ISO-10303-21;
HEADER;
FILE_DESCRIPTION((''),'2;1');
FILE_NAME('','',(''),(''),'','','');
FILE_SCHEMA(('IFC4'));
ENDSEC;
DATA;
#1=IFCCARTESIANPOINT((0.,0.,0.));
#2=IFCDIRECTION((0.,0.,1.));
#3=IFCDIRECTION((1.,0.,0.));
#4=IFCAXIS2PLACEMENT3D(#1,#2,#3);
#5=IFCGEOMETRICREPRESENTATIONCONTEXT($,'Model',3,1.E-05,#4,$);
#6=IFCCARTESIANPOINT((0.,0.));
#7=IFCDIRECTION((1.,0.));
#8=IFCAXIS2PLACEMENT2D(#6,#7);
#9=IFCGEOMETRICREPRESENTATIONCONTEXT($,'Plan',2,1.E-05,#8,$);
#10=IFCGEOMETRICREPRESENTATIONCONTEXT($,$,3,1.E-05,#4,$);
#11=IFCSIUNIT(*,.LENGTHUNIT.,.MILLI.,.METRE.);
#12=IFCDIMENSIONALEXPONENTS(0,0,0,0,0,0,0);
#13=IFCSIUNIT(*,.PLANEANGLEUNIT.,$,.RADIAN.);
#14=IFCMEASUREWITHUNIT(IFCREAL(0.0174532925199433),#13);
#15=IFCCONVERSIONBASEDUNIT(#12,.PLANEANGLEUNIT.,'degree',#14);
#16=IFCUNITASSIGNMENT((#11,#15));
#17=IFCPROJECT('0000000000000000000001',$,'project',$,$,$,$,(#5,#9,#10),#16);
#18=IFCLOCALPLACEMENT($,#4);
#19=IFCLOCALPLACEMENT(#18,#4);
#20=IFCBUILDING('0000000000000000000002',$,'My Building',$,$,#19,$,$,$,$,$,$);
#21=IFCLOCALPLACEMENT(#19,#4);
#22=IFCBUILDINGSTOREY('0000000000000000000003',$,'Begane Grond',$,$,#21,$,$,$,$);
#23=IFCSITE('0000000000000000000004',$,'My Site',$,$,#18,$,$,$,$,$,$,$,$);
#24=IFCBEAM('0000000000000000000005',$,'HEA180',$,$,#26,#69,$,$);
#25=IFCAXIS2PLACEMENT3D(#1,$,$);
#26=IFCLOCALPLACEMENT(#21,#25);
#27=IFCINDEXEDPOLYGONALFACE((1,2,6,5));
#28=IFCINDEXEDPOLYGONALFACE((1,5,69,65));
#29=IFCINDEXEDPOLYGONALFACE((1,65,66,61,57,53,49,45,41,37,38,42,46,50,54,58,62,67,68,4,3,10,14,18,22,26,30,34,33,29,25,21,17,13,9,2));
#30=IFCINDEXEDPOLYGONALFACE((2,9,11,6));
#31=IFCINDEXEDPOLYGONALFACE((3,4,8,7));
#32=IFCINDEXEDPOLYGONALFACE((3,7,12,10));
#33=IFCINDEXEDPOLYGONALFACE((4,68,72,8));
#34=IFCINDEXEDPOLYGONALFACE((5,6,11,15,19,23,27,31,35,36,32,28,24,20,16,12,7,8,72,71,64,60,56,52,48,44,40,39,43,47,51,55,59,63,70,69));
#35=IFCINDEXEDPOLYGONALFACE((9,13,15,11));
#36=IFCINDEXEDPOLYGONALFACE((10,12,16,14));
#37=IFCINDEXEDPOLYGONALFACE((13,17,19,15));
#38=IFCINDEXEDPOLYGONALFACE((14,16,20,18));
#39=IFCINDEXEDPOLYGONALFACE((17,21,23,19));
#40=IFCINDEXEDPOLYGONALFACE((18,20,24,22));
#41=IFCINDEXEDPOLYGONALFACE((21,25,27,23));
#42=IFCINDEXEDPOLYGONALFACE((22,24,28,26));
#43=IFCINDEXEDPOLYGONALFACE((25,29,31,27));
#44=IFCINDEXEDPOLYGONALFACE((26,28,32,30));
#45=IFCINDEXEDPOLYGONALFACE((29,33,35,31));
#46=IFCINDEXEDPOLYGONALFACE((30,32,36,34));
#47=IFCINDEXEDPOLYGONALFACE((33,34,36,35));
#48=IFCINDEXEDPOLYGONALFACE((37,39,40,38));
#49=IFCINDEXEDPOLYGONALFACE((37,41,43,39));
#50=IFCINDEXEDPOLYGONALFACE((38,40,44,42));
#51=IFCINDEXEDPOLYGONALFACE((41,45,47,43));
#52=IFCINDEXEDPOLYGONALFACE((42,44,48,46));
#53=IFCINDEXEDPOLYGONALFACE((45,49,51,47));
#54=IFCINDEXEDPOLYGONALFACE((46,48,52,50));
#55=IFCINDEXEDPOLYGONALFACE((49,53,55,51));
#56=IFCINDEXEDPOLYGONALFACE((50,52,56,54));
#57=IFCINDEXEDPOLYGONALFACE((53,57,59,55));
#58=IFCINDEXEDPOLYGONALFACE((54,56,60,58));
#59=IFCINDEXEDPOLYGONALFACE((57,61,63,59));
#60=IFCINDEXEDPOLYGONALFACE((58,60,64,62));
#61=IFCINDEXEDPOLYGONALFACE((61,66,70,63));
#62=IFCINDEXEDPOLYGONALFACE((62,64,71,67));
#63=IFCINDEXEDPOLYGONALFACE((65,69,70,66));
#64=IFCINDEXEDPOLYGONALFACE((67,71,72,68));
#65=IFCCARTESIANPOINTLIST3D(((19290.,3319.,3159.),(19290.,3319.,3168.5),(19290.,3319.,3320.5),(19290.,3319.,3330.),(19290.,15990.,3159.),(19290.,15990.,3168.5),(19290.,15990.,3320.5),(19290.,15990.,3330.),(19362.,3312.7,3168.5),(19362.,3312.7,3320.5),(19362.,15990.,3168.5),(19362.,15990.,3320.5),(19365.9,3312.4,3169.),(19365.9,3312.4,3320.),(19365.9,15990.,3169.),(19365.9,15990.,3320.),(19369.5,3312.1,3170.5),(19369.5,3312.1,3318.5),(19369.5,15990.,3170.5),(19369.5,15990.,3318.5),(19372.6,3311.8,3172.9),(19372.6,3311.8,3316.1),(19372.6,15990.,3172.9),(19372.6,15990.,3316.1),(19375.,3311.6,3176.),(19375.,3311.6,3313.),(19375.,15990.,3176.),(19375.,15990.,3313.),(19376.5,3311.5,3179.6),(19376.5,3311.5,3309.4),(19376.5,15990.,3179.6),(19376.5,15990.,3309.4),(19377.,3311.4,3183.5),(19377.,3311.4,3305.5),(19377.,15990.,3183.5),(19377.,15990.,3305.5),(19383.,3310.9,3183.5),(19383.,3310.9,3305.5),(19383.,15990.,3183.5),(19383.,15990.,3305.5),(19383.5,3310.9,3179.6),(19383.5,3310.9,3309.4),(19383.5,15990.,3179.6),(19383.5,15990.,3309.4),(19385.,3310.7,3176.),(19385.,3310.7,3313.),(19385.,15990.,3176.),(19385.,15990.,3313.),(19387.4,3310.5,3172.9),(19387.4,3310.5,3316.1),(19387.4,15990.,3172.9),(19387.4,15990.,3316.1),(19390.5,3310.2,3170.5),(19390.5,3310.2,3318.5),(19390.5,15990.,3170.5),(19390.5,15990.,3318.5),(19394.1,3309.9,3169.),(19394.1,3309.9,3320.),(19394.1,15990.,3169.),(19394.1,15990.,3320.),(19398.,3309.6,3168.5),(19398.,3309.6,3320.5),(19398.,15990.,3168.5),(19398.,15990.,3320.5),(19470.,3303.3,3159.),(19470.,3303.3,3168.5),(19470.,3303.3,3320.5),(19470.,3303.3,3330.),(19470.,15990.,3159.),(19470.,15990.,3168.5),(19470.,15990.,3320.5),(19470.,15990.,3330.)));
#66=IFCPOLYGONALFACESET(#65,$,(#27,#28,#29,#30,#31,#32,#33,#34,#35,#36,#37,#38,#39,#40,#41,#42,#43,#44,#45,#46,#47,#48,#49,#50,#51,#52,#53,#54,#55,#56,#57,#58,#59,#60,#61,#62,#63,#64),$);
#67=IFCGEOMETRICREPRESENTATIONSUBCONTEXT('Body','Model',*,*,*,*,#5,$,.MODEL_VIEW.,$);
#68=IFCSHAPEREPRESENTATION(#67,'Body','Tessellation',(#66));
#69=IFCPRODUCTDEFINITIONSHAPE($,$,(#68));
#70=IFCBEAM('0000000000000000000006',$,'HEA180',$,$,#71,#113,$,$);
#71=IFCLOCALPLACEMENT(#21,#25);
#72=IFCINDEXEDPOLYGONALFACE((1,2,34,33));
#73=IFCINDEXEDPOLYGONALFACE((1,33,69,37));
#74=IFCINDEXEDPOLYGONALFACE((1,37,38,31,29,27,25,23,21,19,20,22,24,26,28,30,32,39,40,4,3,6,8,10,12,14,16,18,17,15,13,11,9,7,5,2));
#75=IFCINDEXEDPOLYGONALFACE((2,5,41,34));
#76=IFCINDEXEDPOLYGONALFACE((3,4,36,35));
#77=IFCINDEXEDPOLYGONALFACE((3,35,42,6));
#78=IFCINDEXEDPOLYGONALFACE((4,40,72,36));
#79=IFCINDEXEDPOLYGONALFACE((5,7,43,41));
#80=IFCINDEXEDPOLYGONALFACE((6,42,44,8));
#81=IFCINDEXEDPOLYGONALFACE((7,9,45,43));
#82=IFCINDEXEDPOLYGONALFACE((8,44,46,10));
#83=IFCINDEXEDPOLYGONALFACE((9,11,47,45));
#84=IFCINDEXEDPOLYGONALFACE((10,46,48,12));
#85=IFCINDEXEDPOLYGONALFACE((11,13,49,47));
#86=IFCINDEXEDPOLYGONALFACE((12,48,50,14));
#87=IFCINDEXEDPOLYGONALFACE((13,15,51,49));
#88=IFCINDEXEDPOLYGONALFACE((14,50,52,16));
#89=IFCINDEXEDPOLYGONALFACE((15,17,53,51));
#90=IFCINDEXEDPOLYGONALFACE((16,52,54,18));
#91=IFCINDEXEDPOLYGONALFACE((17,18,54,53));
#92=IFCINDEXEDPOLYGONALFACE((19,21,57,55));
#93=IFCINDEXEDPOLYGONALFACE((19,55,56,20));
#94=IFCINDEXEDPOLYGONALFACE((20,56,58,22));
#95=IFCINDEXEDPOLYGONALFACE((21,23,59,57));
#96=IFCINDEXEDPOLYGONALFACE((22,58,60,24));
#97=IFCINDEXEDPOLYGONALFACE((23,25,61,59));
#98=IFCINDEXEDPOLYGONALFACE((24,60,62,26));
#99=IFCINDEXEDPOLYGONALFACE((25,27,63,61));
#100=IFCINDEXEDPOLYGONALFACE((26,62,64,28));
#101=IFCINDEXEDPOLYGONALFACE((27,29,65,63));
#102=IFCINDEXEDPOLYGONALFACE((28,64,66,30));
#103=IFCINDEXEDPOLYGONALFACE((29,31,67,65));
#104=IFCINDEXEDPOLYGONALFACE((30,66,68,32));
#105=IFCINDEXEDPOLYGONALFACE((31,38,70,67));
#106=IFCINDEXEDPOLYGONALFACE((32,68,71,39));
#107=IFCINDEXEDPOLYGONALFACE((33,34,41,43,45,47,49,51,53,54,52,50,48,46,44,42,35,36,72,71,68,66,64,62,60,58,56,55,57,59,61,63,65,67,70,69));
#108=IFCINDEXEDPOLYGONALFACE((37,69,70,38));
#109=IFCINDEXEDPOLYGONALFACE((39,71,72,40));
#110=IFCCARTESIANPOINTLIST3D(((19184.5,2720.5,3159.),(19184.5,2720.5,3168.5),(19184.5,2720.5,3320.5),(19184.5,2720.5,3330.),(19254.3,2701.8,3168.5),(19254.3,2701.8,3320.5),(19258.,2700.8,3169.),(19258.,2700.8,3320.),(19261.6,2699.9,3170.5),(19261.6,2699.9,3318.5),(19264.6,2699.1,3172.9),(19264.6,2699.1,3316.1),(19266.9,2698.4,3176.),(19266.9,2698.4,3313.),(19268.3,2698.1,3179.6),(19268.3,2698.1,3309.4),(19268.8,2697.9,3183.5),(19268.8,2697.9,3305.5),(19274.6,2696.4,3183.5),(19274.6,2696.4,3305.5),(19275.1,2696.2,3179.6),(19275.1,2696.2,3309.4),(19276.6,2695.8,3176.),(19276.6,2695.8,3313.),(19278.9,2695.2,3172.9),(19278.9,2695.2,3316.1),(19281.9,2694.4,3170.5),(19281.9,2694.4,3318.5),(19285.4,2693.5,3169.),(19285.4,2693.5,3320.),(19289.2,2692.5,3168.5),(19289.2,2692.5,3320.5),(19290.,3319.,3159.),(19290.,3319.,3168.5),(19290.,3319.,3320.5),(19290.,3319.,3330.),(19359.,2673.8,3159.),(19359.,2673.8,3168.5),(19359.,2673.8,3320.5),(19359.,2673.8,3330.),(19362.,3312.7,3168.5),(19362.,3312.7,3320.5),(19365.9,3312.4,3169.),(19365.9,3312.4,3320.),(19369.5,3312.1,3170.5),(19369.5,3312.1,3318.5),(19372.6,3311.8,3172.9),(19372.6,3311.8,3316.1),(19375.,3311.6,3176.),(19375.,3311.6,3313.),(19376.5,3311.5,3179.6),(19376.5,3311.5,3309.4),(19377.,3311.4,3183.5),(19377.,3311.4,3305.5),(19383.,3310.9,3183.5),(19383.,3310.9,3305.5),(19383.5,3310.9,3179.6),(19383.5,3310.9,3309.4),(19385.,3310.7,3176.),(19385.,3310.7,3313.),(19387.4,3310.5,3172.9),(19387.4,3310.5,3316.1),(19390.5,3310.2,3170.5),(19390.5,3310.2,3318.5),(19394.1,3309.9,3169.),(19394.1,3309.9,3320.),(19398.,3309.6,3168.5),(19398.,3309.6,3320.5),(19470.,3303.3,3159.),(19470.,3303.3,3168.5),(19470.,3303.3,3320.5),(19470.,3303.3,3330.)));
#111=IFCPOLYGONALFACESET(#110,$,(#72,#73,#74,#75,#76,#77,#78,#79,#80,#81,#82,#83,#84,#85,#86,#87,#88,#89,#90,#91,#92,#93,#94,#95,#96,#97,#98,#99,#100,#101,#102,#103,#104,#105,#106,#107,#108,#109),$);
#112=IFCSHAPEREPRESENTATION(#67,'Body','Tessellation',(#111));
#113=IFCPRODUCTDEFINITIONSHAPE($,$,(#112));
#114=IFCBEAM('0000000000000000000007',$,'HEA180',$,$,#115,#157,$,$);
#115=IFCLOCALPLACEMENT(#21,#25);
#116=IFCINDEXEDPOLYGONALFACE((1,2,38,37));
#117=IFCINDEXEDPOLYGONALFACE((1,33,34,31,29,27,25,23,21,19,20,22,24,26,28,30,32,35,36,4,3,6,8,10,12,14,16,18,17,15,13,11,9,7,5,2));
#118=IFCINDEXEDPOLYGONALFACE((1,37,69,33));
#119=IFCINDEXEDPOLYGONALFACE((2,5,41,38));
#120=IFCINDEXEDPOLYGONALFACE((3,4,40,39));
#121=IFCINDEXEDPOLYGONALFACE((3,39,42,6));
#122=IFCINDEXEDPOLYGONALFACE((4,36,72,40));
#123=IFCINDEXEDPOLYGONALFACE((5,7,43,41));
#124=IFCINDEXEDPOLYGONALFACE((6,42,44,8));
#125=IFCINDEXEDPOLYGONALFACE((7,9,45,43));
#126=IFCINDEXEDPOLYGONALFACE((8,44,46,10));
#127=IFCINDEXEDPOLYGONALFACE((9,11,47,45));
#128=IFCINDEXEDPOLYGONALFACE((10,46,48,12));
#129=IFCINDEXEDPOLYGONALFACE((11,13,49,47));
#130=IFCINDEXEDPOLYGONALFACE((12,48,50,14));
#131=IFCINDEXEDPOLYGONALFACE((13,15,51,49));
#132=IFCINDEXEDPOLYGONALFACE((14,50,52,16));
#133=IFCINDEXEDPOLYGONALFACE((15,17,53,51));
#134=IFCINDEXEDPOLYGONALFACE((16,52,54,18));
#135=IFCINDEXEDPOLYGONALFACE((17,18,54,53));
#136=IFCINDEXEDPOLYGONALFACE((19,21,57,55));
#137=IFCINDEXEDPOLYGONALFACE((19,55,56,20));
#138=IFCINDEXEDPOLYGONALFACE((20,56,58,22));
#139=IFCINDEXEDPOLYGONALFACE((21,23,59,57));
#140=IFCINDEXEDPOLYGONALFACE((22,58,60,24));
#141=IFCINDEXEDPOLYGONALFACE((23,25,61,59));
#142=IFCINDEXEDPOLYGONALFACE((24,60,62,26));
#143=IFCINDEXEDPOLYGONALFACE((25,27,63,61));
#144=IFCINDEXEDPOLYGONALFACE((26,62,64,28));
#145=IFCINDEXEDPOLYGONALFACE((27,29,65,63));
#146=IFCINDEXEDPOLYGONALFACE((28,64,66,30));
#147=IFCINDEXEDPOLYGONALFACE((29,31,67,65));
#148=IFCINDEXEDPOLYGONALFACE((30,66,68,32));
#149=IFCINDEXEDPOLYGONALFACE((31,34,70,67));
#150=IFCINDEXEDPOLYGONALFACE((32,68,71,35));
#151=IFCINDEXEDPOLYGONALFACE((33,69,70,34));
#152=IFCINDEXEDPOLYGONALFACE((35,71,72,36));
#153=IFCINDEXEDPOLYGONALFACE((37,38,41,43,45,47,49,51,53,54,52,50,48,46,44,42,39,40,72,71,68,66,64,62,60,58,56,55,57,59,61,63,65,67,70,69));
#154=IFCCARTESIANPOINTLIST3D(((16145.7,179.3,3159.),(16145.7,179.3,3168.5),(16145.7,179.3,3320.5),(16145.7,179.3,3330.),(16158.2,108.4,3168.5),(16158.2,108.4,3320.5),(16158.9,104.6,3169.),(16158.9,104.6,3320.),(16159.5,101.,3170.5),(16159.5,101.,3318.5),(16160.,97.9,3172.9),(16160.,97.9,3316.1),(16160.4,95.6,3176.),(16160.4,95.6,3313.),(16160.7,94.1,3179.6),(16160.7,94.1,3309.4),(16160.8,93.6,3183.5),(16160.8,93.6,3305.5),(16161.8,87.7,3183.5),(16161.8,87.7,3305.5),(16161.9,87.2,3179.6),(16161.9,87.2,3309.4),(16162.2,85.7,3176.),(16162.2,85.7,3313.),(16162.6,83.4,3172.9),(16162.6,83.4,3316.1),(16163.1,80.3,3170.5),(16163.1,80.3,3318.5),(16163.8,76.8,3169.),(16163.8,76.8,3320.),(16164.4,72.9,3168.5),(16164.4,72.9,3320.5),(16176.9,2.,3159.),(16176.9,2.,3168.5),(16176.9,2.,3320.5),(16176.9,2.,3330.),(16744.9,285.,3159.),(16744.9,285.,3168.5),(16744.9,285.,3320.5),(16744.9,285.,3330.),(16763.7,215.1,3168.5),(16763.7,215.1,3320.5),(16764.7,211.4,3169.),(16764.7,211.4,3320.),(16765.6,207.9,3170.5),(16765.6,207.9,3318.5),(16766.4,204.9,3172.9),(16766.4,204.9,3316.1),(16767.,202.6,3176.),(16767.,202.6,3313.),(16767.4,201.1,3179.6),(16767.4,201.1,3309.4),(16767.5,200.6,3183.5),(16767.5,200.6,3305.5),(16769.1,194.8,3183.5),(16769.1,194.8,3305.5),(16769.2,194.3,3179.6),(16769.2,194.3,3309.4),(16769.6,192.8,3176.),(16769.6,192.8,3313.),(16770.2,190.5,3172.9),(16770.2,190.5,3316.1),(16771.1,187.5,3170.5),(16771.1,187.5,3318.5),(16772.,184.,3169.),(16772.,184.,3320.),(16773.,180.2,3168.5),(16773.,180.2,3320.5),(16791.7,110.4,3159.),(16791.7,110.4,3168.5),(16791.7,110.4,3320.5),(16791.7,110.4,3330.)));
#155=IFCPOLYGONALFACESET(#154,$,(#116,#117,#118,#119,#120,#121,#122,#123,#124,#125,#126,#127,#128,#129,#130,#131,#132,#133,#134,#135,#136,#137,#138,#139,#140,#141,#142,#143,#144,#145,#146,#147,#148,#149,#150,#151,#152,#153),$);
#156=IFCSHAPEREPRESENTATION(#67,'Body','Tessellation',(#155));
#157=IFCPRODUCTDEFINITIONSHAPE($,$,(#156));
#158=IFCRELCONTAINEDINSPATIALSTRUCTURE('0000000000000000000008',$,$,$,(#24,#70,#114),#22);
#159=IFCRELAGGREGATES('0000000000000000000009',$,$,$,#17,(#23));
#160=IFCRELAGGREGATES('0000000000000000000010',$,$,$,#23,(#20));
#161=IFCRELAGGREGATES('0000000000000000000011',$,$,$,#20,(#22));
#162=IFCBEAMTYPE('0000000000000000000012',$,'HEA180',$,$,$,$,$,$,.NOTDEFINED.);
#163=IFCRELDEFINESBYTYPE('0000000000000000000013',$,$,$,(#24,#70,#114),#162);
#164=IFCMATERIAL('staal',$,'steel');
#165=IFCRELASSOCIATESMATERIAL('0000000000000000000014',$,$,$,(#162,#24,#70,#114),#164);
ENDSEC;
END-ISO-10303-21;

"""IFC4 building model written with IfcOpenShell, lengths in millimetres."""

from ifc_helpers import new_model, entity, si_unit, converted_unit, frame, origin_with_axes, origin_2d_with_axis, place, context, subcontext, project, spatial, i_section, extrude, clip, halfspace, material, material_profile, profile_set, profile_usage, type_object, element, save


model = new_model("IFC4")

# Units and contexts
model_context = context("Model", 3, precision=1e-05, world=origin_with_axes())
plan_context = context("Plan", 2, precision=1e-05, world=origin_2d_with_axis())
context_of_model = context(None, 3, precision=1e-05, world=origin_with_axes())
body_context = subcontext(model_context, "Body", "Model", "MODEL_VIEW")
ifc_project = project(units=[si_unit("LENGTHUNIT", "METRE", prefix="MILLI"), converted_unit("PLANEANGLEUNIT", "degree", entity("IfcReal", 0.0174532925199433), si_unit("PLANEANGLEUNIT", "RADIAN"), dimensions=[0, 0, 0, 0, 0, 0, 0])], contexts=[model_context, plan_context, context_of_model])

# Site, building, storey
site_placement = place(None, origin_with_axes())
site = spatial("IfcSite", under=ifc_project, at=site_placement, Name="My Site")
building_placement = place(site_placement, origin_with_axes())
building = spatial("IfcBuilding", under=site, at=building_placement, Name="My Building")
storey_placement = place(building_placement, origin_with_axes())
storey = spatial("IfcBuildingStorey", under=building, at=storey_placement, Name="Begane Grond")

# Shared definitions
ifc_material = material(Name="staal", Category="steel")

# Beams
ifc_material_profile_1 = material_profile(ifc_material, i_section(OverallWidth=180.0, OverallDepth=171.0, WebThickness=6.0, FlangeThickness=9.5, FilletRadius=15.0))
ifc_profile_set_1 = profile_set([ifc_material_profile_1], Name="HEA180")
beam_type_1 = type_object("IfcBeamType", Name="HEA180", PredefinedType="NOTDEFINED", material=ifc_profile_set_1)
ifc_profile_usage_1 = profile_usage(ifc_profile_set_1)
beam_1_placement = place(storey_placement, frame((19380.0, 15990.0, 3244.5), z_axis=(0.0, -1.0, 0.0), x_axis=(1.0, 0.0, 0.0)))
element("IfcBeam", 1, at=beam_1_placement, inside=storey, type_object=beam_type_1, material=ifc_profile_usage_1, Name="HEA180", context=body_context, shape_type="Clipping", body=[
    clip(extrude(i_section(OverallWidth=180.0, OverallDepth=171.0, WebThickness=6.0, FlangeThickness=9.5, FilletRadius=15.0), origin_with_axes(), (0.0, 0.0, 1.0), 13377.1), halfspace(frame((90.0, -3244.5, 12686.7), z_axis=(-0.087123, 0.0, 0.996198), x_axis=(-0.000001, 1.0, 0.0)), False)),
])
ifc_profile_usage_2 = profile_usage(ifc_profile_set_1)
beam_2_placement = place(storey_placement, frame((19501.3, 3998.8, 3244.5), z_axis=(-0.173648, -0.984808, 0.0), x_axis=(0.984808, -0.173648, 0.0)))
element("IfcBeam", 2, at=beam_2_placement, inside=storey, type_object=beam_type_1, material=ifc_profile_usage_2, Name="HEA180", context=body_context, shape_type="Clipping", body=[
    clip(clip(extrude(i_section(OverallWidth=180.0, OverallDepth=171.0, WebThickness=6.0, FlangeThickness=9.5, FilletRadius=15.0), origin_with_axes(), (0.0, 0.0, 1.0), 2020.1), halfspace(frame((90.0, -3254.0, 690.4), z_axis=(-0.087188, 0.0, -0.996192), x_axis=(0.000001, 1.0, 0.0)), False)), halfspace(frame((90.0, -3254.0, 1329.6), z_axis=(-0.087089, 0.0, 0.996201), x_axis=(0.0, 1.0, 0.0)), False)),
])
ifc_profile_usage_3 = profile_usage(ifc_profile_set_1)
beam_3_placement = place(storey_placement, frame((17456.0, 319.0, 3244.5), z_axis=(-0.984808, -0.173648, 0.0), x_axis=(0.173648, -0.984808, 0.0)))
element("IfcBeam", 3, at=beam_3_placement, inside=storey, type_object=beam_type_1, material=ifc_profile_usage_3, Name="HEA180", context=body_context, shape_type="Clipping", body=[
    clip(extrude(i_section(OverallWidth=180.0, OverallDepth=171.0, WebThickness=6.0, FlangeThickness=9.5, FilletRadius=15.0), origin_with_axes(), (0.0, 0.0, 1.0), 1314.7), halfspace(frame((90.0, -3244.5, 690.4), z_axis=(-0.087167, 0.0, -0.996194), x_axis=(-0.000001, 1.0, 0.0)), False)),
])

save(model, "model.ifc")
